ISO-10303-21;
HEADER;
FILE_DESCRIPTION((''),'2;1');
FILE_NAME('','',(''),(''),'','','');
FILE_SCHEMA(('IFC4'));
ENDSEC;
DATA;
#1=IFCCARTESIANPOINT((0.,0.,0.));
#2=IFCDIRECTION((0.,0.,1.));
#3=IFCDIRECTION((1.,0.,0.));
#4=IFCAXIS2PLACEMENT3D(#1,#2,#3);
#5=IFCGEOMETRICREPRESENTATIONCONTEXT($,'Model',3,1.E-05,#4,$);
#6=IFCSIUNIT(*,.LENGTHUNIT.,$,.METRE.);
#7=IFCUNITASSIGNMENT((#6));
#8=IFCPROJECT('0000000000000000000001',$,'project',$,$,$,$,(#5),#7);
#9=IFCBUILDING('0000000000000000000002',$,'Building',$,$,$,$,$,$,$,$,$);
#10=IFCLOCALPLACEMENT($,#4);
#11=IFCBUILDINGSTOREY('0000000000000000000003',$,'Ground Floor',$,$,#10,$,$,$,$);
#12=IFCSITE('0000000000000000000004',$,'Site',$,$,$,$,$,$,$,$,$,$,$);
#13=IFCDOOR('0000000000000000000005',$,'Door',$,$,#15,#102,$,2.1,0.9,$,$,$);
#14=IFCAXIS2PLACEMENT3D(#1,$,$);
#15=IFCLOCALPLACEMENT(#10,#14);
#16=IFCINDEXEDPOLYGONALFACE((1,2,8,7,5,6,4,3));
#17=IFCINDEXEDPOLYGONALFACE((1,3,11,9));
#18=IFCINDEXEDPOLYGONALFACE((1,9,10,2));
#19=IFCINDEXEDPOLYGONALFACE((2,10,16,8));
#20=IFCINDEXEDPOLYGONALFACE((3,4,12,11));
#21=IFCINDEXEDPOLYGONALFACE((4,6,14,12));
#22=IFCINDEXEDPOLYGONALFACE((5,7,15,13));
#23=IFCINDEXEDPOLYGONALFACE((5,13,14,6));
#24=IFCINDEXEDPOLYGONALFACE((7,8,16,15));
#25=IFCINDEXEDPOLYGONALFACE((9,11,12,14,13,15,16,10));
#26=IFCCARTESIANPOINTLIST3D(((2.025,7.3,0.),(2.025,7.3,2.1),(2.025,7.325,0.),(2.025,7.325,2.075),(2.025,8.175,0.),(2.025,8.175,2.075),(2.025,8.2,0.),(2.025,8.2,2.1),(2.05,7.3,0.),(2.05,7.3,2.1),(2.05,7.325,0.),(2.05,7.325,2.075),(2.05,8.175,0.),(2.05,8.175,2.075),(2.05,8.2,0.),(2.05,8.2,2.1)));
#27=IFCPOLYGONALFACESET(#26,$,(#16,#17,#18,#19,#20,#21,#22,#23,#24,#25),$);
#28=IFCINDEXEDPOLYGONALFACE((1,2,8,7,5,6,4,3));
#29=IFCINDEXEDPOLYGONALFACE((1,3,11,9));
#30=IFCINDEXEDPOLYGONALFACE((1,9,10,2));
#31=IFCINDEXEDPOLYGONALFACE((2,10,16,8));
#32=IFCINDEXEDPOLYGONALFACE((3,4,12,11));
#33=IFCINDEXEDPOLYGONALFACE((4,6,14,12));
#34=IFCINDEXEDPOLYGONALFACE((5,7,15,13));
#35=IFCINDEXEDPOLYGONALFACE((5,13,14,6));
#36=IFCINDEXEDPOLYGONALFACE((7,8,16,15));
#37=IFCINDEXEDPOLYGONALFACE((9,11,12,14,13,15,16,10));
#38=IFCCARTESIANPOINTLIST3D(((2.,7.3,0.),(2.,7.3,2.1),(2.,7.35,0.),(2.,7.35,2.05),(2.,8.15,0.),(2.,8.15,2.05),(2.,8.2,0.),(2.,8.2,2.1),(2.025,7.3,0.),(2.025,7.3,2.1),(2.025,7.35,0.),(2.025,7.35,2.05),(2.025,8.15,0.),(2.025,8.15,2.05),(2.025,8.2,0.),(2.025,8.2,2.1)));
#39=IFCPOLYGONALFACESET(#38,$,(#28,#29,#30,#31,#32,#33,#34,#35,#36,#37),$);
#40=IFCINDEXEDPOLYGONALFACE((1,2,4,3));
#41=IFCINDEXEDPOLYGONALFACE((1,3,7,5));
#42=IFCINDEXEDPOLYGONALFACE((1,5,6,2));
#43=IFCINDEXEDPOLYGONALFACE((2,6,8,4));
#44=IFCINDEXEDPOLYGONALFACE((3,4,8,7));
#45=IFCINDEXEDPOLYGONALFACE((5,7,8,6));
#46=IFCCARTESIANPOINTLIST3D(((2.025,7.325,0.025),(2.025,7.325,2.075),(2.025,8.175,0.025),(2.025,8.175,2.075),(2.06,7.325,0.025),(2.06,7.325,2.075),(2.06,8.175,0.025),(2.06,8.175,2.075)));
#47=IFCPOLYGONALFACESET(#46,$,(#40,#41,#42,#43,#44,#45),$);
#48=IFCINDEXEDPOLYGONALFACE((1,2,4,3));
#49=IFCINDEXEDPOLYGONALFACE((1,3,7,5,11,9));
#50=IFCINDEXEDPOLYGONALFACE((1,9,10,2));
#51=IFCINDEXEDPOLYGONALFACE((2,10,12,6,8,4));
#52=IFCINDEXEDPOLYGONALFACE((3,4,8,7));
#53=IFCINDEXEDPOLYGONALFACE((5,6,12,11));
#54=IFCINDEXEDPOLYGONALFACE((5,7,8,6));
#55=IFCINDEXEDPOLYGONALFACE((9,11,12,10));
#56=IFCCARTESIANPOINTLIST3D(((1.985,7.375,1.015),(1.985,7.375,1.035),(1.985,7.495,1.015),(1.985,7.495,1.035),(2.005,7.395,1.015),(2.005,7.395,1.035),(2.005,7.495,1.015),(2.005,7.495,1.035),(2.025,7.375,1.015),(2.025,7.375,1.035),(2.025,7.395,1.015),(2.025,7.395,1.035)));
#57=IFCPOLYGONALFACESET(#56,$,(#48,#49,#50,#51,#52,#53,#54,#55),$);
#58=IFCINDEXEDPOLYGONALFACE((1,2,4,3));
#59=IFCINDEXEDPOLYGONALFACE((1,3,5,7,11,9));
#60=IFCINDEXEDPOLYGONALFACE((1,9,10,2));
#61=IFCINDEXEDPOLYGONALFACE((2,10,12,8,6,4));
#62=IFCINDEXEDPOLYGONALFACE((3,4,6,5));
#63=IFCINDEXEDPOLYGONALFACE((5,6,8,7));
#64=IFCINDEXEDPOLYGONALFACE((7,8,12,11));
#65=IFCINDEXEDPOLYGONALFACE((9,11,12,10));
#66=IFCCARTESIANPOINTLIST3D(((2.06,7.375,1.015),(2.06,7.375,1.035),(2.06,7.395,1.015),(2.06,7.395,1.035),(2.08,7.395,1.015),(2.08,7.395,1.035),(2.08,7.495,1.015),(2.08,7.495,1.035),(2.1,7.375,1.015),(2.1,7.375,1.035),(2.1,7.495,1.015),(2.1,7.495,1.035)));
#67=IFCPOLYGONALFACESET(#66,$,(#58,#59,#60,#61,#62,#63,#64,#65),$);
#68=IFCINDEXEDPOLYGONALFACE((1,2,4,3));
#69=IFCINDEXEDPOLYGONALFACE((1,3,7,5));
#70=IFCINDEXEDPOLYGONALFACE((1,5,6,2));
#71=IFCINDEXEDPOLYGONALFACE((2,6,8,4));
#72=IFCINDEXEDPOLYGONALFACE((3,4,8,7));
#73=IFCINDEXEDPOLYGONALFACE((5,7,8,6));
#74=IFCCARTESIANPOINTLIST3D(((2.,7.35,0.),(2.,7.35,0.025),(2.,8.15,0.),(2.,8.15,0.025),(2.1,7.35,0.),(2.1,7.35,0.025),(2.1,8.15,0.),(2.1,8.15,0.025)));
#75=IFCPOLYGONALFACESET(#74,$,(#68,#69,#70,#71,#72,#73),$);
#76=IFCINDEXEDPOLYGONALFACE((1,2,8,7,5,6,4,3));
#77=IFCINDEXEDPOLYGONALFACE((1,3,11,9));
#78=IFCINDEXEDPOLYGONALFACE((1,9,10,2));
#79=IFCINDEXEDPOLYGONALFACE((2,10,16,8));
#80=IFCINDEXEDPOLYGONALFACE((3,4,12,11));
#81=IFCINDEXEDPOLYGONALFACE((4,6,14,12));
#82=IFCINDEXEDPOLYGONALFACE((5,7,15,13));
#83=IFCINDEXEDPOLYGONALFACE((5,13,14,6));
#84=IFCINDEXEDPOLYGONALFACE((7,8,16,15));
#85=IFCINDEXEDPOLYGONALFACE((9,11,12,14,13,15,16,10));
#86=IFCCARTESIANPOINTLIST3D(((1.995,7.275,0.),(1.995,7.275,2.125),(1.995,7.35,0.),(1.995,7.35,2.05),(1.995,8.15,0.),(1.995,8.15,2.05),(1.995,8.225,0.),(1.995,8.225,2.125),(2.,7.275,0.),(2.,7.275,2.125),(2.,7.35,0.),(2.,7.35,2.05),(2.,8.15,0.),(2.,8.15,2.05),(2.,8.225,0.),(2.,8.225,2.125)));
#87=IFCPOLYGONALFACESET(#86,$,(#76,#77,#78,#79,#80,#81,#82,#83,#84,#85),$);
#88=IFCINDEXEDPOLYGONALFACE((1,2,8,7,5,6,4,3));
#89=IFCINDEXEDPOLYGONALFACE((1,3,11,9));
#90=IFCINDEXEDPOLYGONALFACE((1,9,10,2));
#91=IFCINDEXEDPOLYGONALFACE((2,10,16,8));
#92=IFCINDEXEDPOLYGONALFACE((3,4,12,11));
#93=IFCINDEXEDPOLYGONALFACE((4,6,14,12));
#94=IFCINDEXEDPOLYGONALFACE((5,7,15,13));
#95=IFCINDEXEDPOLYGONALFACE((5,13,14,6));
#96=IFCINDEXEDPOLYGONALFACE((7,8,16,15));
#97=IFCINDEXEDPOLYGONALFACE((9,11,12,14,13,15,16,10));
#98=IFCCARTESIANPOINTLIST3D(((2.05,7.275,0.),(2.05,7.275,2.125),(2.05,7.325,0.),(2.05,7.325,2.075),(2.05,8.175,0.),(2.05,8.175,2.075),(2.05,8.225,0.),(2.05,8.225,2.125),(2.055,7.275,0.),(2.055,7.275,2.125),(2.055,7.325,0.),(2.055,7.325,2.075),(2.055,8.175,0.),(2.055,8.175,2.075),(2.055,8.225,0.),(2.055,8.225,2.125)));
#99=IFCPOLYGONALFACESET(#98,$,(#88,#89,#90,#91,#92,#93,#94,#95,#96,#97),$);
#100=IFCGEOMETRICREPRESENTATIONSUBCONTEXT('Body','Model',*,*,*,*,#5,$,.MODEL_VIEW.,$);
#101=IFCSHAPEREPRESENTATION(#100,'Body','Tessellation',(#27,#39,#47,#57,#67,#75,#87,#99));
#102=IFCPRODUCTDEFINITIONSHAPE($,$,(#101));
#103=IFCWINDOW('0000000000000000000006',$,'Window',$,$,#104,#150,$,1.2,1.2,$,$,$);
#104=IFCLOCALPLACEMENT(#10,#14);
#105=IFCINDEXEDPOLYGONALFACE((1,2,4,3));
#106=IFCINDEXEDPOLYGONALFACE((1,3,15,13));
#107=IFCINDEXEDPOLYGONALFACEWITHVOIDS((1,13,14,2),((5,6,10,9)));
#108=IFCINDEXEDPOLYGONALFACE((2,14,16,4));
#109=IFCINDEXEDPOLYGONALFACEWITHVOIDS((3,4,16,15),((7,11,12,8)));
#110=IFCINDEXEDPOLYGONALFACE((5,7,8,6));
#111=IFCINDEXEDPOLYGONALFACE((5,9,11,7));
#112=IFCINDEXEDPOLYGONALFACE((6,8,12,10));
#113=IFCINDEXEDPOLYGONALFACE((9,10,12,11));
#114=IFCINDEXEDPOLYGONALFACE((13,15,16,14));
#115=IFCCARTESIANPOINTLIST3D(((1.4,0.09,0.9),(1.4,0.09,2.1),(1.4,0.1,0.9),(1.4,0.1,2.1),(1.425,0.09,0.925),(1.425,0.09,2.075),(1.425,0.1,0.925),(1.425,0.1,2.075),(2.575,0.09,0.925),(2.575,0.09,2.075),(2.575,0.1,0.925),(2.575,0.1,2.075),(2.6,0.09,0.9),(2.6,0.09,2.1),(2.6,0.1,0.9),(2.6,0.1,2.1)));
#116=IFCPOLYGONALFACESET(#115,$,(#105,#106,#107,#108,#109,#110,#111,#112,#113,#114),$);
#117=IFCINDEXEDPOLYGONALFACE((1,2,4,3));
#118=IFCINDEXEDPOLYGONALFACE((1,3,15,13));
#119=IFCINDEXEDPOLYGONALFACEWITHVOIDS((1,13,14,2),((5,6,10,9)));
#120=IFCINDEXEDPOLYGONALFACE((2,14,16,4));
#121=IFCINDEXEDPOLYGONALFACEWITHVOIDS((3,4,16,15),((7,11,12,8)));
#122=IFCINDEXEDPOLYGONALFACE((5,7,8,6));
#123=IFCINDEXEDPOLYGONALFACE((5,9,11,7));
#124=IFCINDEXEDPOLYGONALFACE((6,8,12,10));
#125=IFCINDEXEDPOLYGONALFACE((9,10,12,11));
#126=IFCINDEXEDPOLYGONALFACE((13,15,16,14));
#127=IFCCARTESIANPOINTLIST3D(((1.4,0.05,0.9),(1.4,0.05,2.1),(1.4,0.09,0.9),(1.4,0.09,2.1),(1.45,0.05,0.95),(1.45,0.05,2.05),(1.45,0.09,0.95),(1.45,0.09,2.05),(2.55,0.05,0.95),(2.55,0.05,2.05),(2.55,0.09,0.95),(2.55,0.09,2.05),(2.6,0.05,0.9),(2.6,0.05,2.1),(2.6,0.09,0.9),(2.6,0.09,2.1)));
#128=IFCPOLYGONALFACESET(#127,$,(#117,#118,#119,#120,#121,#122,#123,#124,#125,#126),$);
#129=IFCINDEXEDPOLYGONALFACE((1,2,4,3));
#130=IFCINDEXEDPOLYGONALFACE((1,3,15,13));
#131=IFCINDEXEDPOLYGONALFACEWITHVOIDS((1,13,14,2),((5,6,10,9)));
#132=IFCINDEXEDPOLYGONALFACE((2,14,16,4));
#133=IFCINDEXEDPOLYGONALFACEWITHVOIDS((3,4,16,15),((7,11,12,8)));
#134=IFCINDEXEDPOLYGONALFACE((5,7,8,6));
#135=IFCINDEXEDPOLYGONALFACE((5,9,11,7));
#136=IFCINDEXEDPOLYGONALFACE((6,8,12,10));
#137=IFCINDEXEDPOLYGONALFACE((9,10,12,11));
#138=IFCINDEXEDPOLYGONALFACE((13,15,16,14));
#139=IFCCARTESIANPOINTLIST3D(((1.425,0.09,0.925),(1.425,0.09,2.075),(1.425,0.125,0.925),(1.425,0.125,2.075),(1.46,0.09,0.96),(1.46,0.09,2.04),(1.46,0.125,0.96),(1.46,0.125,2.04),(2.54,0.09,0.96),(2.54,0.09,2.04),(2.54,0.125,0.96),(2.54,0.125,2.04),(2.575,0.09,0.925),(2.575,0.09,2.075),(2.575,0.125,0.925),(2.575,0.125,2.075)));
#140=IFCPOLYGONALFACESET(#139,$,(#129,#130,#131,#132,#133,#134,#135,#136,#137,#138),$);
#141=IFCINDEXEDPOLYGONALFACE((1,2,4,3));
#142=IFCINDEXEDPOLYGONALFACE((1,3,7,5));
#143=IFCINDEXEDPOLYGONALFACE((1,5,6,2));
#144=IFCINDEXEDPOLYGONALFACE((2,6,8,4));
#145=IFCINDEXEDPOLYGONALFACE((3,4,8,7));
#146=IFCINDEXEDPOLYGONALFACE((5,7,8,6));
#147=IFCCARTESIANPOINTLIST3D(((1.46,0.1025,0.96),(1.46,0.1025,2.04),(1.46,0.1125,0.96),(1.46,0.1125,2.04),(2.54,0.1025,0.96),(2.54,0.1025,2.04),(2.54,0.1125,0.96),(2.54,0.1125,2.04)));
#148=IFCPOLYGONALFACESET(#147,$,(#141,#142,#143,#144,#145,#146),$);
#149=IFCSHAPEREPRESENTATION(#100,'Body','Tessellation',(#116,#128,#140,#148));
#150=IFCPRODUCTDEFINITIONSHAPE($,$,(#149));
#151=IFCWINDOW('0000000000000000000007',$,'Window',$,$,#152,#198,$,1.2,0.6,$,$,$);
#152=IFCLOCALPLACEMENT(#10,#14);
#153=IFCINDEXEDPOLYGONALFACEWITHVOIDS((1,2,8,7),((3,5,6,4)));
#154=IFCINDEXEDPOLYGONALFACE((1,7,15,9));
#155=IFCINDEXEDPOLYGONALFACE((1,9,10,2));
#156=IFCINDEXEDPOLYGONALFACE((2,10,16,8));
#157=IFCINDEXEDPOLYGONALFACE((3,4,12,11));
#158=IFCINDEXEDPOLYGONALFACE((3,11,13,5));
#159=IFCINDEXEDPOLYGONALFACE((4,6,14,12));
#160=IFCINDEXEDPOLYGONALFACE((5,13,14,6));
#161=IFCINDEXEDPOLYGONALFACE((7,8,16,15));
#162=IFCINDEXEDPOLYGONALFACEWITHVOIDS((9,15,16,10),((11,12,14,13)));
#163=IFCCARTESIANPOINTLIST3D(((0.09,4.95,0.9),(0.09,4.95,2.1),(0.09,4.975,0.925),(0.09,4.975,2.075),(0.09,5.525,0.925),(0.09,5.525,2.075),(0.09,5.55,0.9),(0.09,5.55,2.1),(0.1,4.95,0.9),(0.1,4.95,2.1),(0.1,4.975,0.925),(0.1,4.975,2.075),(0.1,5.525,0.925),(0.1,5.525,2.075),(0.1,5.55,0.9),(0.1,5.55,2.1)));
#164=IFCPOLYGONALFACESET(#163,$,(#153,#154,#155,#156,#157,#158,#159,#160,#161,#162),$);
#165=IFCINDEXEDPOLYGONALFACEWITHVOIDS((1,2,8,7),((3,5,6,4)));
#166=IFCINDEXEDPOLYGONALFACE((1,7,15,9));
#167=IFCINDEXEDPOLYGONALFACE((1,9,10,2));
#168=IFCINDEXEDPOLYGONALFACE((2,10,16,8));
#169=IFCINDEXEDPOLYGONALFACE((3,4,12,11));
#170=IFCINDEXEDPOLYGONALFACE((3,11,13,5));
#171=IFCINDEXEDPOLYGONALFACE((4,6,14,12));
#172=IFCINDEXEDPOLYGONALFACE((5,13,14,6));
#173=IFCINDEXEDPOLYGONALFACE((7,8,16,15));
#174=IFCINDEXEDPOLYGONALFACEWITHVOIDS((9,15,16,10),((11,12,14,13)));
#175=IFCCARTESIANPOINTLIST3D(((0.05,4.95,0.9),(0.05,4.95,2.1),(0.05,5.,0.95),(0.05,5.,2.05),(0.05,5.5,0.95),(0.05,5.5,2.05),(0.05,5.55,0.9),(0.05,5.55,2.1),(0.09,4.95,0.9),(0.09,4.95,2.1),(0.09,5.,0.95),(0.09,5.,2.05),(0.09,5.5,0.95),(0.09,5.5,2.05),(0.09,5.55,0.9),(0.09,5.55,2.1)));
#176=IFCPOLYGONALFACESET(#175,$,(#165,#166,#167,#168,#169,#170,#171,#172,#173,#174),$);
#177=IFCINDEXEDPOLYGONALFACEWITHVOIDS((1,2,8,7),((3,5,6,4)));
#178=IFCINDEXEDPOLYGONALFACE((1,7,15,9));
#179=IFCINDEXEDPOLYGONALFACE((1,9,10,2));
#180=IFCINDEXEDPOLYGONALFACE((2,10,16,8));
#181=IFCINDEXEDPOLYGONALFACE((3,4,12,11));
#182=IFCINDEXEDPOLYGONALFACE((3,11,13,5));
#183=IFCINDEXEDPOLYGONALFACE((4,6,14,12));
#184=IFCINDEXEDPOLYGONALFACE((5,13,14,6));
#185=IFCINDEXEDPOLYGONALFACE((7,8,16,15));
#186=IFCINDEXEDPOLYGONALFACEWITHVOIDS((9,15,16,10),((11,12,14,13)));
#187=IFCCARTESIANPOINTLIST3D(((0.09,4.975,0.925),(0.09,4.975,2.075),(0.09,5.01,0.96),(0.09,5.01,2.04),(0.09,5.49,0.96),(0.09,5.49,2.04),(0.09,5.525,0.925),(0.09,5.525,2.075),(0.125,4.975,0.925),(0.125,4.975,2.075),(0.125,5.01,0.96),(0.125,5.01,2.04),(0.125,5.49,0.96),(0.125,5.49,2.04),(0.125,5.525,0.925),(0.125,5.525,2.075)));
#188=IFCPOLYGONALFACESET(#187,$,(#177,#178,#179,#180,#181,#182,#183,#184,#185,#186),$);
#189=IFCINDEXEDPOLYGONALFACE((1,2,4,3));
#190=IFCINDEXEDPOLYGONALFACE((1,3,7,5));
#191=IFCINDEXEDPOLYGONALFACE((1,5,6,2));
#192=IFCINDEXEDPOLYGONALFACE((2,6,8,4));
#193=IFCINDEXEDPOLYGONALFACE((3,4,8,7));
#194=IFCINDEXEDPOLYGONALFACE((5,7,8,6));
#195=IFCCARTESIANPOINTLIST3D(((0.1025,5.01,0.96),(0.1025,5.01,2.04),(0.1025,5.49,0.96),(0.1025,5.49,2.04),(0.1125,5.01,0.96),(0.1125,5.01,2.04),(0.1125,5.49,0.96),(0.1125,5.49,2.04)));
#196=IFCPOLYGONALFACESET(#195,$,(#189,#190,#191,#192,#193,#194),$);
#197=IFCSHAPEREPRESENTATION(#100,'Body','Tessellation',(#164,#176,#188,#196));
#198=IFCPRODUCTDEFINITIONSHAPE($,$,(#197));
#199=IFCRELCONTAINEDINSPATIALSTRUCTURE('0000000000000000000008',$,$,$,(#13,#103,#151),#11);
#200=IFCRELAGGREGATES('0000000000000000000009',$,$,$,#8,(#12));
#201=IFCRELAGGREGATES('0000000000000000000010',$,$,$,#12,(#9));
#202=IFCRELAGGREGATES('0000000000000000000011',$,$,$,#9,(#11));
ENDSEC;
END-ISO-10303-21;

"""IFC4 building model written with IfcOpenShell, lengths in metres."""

from ifc_helpers import new_model, si_unit, frame, origin_with_axes, place, context, subcontext, project, spatial, line, indexed_curve, outline, extrude, element, save


model = new_model("IFC4")

# Units and contexts
model_context = context("Model", 3, precision=1e-05, world=origin_with_axes())
body_context = subcontext(model_context, "Body", "Model", "MODEL_VIEW")
ifc_project = project(units=[si_unit("LENGTHUNIT", "METRE")], contexts=[model_context])

# Site, building, storey
site = spatial("IfcSite", under=ifc_project, Name="Site")
building = spatial("IfcBuilding", under=site, Name="Building")
storey_placement = place(None, origin_with_axes())
storey = spatial("IfcBuildingStorey", under=building, at=storey_placement, Name="Ground Floor")

# Door
door_1_placement = place(storey_placement, frame((2.0, 8.2, 0.0), z_axis=(0.0, 0.0, 1.0), x_axis=(0.0, -1.0, 0.0)))
element("IfcDoor", 1, at=door_1_placement, inside=storey, Name="Door", OverallHeight=2.1, OverallWidth=0.9, context=body_context, shape_type="SweptSolid", body=[
    extrude(outline(indexed_curve([(0.0, 0.0), (0.0, 2.1), (0.9, 2.1), (0.9, 0.0), (0.875, 0.0), (0.875, 2.075), (0.025, 2.075), (0.025, 0.0)], segments=[line(1, 2, 3, 4, 5, 6, 7, 8, 1)])), frame((0.0, 0.025, 0.0), z_axis=(0.0, -1.0, 0.0), x_axis=(1.0, 0.0, 0.0)), (0.0, 0.0, -1.0), 0.025),
    extrude(outline(indexed_curve([(0.0, 0.0), (0.0, 2.1), (0.9, 2.1), (0.9, 0.0), (0.85, 0.0), (0.85, 2.05), (0.05, 2.05), (0.05, 0.0)], segments=[line(1, 2, 3, 4, 5, 6, 7, 8, 1)])), frame((0.0, 0.0, 0.0), z_axis=(0.0, -1.0, 0.0), x_axis=(1.0, 0.0, 0.0)), (0.0, 0.0, -1.0), 0.025),
    extrude(outline(indexed_curve([(0.0, 0.0), (0.85, 0.0), (0.85, 0.035), (0.0, 0.035)], segments=[line(1, 2, 3, 4, 1)])), frame((0.025, 0.025, 0.025), z_axis=(0.0, 0.0, 1.0), x_axis=(1.0, 0.0, 0.0)), (0.0, 0.0, 1.0), 2.05),
    extrude(outline(indexed_curve([(0.0, 0.0), (0.0, -0.04), (-0.12, -0.04), (-0.12, -0.02), (-0.02, -0.02), (-0.02, 0.0)], segments=[line(1, 2, 3, 4, 5, 6, 1)])), frame((0.825, 0.025, 1.015), z_axis=(0.0, 0.0, 1.0), x_axis=(1.0, 0.0, 0.0)), (0.0, 0.0, 1.0), 0.02),
    extrude(outline(indexed_curve([(0.0, 0.0), (0.0, 0.04), (-0.12, 0.04), (-0.12, 0.02), (-0.02, 0.02), (-0.02, 0.0)], segments=[line(1, 2, 3, 4, 5, 6, 1)])), frame((0.825, 0.06, 1.015), z_axis=(0.0, 0.0, 1.0), x_axis=(1.0, 0.0, 0.0)), (0.0, 0.0, 1.0), 0.02),
    extrude(outline(indexed_curve([(0.0, 0.0), (0.8, 0.0), (0.8, 0.1), (0.0, 0.1)], segments=[line(1, 2, 3, 4, 1)])), frame((0.05, 0.0, 0.0), z_axis=(0.0, 0.0, 1.0), x_axis=(1.0, 0.0, 0.0)), (0.0, 0.0, 1.0), 0.025),
    extrude(outline(indexed_curve([(0.0, 0.0), (0.0, 2.125), (0.95, 2.125), (0.95, 0.0), (0.875, 0.0), (0.875, 2.05), (0.075, 2.05), (0.075, 0.0)], segments=[line(1, 2, 3, 4, 5, 6, 7, 8, 1)])), frame((-0.025, -0.005, 0.0), z_axis=(0.0, -1.0, 0.0), x_axis=(1.0, 0.0, 0.0)), (0.0, 0.0, -1.0), 0.005),
    extrude(outline(indexed_curve([(0.0, 0.0), (0.0, 2.125), (0.95, 2.125), (0.95, 0.0), (0.9, 0.0), (0.9, 2.075), (0.05, 2.075), (0.05, 0.0)], segments=[line(1, 2, 3, 4, 5, 6, 7, 8, 1)])), frame((-0.025, 0.05, 0.0), z_axis=(0.0, -1.0, 0.0), x_axis=(1.0, 0.0, 0.0)), (0.0, 0.0, -1.0), 0.005),
])

# Windows
window_1_placement = place(storey_placement, frame((1.4, 0.0, 0.9), z_axis=(0.0, 0.0, 1.0), x_axis=(1.0, 0.0, 0.0)))
element("IfcWindow", 2, at=window_1_placement, inside=storey, Name="Window", OverallHeight=1.2, OverallWidth=1.2, context=body_context, shape_type="SweptSolid", body=[
    extrude(outline(indexed_curve([(0.0, 0.0), (1.2, 0.0), (1.2, 1.2), (0.0, 1.2)], segments=[line(1, 2, 3, 4, 1)]), holes=[indexed_curve([(0.025, 0.025), (1.175, 0.025), (1.175, 1.175), (0.025, 1.175)], segments=[line(1, 2, 3, 4, 1)])]), frame((0.0, 0.09, 0.0), z_axis=(0.0, -1.0, 0.0), x_axis=(1.0, 0.0, 0.0)), (0.0, 0.0, -1.0), 0.01),
    extrude(outline(indexed_curve([(0.0, 0.0), (1.2, 0.0), (1.2, 1.2), (0.0, 1.2)], segments=[line(1, 2, 3, 4, 1)]), holes=[indexed_curve([(0.05, 0.05), (1.15, 0.05), (1.15, 1.15), (0.05, 1.15)], segments=[line(1, 2, 3, 4, 1)])]), frame((0.0, 0.05, 0.0), z_axis=(0.0, -1.0, 0.0), x_axis=(1.0, 0.0, 0.0)), (0.0, 0.0, -1.0), 0.04),
    extrude(outline(indexed_curve([(0.0, 0.0), (1.15, 0.0), (1.15, 1.15), (0.0, 1.15)], segments=[line(1, 2, 3, 4, 1)]), holes=[indexed_curve([(0.035, 0.035), (1.115, 0.035), (1.115, 1.115), (0.035, 1.115)], segments=[line(1, 2, 3, 4, 1)])]), frame((0.025, 0.09, 0.025), z_axis=(0.0, -1.0, 0.0), x_axis=(1.0, 0.0, 0.0)), (0.0, 0.0, -1.0), 0.035),
    extrude(outline(indexed_curve([(0.035, 0.035), (1.115, 0.035), (1.115, 1.115), (0.035, 1.115)], segments=[line(1, 2, 3, 4, 1)])), frame((0.025, 0.1025, 0.025), z_axis=(0.0, -1.0, 0.0), x_axis=(1.0, 0.0, 0.0)), (0.0, 0.0, -1.0), 0.01),
])
window_2_placement = place(storey_placement, frame((0.0, 5.55, 0.9), z_axis=(0.0, 0.0, 1.0), x_axis=(0.0, -1.0, 0.0)))
element("IfcWindow", 3, at=window_2_placement, inside=storey, Name="Window", OverallHeight=1.2, OverallWidth=0.6, context=body_context, shape_type="SweptSolid", body=[
    extrude(outline(indexed_curve([(0.0, 0.0), (0.6, 0.0), (0.6, 1.2), (0.0, 1.2)], segments=[line(1, 2, 3, 4, 1)]), holes=[indexed_curve([(0.025, 0.025), (0.575, 0.025), (0.575, 1.175), (0.025, 1.175)], segments=[line(1, 2, 3, 4, 1)])]), frame((0.0, 0.09, 0.0), z_axis=(0.0, -1.0, 0.0), x_axis=(1.0, 0.0, 0.0)), (0.0, 0.0, -1.0), 0.01),
    extrude(outline(indexed_curve([(0.0, 0.0), (0.6, 0.0), (0.6, 1.2), (0.0, 1.2)], segments=[line(1, 2, 3, 4, 1)]), holes=[indexed_curve([(0.05, 0.05), (0.55, 0.05), (0.55, 1.15), (0.05, 1.15)], segments=[line(1, 2, 3, 4, 1)])]), frame((0.0, 0.05, 0.0), z_axis=(0.0, -1.0, 0.0), x_axis=(1.0, 0.0, 0.0)), (0.0, 0.0, -1.0), 0.04),
    extrude(outline(indexed_curve([(0.0, 0.0), (0.55, 0.0), (0.55, 1.15), (0.0, 1.15)], segments=[line(1, 2, 3, 4, 1)]), holes=[indexed_curve([(0.035, 0.035), (0.515, 0.035), (0.515, 1.115), (0.035, 1.115)], segments=[line(1, 2, 3, 4, 1)])]), frame((0.025, 0.09, 0.025), z_axis=(0.0, -1.0, 0.0), x_axis=(1.0, 0.0, 0.0)), (0.0, 0.0, -1.0), 0.035),
    extrude(outline(indexed_curve([(0.035, 0.035), (0.515, 0.035), (0.515, 1.115), (0.035, 1.115)], segments=[line(1, 2, 3, 4, 1)])), frame((0.025, 0.1025, 0.025), z_axis=(0.0, -1.0, 0.0), x_axis=(1.0, 0.0, 0.0)), (0.0, 0.0, -1.0), 0.01),
])

save(model, "model.ifc")
